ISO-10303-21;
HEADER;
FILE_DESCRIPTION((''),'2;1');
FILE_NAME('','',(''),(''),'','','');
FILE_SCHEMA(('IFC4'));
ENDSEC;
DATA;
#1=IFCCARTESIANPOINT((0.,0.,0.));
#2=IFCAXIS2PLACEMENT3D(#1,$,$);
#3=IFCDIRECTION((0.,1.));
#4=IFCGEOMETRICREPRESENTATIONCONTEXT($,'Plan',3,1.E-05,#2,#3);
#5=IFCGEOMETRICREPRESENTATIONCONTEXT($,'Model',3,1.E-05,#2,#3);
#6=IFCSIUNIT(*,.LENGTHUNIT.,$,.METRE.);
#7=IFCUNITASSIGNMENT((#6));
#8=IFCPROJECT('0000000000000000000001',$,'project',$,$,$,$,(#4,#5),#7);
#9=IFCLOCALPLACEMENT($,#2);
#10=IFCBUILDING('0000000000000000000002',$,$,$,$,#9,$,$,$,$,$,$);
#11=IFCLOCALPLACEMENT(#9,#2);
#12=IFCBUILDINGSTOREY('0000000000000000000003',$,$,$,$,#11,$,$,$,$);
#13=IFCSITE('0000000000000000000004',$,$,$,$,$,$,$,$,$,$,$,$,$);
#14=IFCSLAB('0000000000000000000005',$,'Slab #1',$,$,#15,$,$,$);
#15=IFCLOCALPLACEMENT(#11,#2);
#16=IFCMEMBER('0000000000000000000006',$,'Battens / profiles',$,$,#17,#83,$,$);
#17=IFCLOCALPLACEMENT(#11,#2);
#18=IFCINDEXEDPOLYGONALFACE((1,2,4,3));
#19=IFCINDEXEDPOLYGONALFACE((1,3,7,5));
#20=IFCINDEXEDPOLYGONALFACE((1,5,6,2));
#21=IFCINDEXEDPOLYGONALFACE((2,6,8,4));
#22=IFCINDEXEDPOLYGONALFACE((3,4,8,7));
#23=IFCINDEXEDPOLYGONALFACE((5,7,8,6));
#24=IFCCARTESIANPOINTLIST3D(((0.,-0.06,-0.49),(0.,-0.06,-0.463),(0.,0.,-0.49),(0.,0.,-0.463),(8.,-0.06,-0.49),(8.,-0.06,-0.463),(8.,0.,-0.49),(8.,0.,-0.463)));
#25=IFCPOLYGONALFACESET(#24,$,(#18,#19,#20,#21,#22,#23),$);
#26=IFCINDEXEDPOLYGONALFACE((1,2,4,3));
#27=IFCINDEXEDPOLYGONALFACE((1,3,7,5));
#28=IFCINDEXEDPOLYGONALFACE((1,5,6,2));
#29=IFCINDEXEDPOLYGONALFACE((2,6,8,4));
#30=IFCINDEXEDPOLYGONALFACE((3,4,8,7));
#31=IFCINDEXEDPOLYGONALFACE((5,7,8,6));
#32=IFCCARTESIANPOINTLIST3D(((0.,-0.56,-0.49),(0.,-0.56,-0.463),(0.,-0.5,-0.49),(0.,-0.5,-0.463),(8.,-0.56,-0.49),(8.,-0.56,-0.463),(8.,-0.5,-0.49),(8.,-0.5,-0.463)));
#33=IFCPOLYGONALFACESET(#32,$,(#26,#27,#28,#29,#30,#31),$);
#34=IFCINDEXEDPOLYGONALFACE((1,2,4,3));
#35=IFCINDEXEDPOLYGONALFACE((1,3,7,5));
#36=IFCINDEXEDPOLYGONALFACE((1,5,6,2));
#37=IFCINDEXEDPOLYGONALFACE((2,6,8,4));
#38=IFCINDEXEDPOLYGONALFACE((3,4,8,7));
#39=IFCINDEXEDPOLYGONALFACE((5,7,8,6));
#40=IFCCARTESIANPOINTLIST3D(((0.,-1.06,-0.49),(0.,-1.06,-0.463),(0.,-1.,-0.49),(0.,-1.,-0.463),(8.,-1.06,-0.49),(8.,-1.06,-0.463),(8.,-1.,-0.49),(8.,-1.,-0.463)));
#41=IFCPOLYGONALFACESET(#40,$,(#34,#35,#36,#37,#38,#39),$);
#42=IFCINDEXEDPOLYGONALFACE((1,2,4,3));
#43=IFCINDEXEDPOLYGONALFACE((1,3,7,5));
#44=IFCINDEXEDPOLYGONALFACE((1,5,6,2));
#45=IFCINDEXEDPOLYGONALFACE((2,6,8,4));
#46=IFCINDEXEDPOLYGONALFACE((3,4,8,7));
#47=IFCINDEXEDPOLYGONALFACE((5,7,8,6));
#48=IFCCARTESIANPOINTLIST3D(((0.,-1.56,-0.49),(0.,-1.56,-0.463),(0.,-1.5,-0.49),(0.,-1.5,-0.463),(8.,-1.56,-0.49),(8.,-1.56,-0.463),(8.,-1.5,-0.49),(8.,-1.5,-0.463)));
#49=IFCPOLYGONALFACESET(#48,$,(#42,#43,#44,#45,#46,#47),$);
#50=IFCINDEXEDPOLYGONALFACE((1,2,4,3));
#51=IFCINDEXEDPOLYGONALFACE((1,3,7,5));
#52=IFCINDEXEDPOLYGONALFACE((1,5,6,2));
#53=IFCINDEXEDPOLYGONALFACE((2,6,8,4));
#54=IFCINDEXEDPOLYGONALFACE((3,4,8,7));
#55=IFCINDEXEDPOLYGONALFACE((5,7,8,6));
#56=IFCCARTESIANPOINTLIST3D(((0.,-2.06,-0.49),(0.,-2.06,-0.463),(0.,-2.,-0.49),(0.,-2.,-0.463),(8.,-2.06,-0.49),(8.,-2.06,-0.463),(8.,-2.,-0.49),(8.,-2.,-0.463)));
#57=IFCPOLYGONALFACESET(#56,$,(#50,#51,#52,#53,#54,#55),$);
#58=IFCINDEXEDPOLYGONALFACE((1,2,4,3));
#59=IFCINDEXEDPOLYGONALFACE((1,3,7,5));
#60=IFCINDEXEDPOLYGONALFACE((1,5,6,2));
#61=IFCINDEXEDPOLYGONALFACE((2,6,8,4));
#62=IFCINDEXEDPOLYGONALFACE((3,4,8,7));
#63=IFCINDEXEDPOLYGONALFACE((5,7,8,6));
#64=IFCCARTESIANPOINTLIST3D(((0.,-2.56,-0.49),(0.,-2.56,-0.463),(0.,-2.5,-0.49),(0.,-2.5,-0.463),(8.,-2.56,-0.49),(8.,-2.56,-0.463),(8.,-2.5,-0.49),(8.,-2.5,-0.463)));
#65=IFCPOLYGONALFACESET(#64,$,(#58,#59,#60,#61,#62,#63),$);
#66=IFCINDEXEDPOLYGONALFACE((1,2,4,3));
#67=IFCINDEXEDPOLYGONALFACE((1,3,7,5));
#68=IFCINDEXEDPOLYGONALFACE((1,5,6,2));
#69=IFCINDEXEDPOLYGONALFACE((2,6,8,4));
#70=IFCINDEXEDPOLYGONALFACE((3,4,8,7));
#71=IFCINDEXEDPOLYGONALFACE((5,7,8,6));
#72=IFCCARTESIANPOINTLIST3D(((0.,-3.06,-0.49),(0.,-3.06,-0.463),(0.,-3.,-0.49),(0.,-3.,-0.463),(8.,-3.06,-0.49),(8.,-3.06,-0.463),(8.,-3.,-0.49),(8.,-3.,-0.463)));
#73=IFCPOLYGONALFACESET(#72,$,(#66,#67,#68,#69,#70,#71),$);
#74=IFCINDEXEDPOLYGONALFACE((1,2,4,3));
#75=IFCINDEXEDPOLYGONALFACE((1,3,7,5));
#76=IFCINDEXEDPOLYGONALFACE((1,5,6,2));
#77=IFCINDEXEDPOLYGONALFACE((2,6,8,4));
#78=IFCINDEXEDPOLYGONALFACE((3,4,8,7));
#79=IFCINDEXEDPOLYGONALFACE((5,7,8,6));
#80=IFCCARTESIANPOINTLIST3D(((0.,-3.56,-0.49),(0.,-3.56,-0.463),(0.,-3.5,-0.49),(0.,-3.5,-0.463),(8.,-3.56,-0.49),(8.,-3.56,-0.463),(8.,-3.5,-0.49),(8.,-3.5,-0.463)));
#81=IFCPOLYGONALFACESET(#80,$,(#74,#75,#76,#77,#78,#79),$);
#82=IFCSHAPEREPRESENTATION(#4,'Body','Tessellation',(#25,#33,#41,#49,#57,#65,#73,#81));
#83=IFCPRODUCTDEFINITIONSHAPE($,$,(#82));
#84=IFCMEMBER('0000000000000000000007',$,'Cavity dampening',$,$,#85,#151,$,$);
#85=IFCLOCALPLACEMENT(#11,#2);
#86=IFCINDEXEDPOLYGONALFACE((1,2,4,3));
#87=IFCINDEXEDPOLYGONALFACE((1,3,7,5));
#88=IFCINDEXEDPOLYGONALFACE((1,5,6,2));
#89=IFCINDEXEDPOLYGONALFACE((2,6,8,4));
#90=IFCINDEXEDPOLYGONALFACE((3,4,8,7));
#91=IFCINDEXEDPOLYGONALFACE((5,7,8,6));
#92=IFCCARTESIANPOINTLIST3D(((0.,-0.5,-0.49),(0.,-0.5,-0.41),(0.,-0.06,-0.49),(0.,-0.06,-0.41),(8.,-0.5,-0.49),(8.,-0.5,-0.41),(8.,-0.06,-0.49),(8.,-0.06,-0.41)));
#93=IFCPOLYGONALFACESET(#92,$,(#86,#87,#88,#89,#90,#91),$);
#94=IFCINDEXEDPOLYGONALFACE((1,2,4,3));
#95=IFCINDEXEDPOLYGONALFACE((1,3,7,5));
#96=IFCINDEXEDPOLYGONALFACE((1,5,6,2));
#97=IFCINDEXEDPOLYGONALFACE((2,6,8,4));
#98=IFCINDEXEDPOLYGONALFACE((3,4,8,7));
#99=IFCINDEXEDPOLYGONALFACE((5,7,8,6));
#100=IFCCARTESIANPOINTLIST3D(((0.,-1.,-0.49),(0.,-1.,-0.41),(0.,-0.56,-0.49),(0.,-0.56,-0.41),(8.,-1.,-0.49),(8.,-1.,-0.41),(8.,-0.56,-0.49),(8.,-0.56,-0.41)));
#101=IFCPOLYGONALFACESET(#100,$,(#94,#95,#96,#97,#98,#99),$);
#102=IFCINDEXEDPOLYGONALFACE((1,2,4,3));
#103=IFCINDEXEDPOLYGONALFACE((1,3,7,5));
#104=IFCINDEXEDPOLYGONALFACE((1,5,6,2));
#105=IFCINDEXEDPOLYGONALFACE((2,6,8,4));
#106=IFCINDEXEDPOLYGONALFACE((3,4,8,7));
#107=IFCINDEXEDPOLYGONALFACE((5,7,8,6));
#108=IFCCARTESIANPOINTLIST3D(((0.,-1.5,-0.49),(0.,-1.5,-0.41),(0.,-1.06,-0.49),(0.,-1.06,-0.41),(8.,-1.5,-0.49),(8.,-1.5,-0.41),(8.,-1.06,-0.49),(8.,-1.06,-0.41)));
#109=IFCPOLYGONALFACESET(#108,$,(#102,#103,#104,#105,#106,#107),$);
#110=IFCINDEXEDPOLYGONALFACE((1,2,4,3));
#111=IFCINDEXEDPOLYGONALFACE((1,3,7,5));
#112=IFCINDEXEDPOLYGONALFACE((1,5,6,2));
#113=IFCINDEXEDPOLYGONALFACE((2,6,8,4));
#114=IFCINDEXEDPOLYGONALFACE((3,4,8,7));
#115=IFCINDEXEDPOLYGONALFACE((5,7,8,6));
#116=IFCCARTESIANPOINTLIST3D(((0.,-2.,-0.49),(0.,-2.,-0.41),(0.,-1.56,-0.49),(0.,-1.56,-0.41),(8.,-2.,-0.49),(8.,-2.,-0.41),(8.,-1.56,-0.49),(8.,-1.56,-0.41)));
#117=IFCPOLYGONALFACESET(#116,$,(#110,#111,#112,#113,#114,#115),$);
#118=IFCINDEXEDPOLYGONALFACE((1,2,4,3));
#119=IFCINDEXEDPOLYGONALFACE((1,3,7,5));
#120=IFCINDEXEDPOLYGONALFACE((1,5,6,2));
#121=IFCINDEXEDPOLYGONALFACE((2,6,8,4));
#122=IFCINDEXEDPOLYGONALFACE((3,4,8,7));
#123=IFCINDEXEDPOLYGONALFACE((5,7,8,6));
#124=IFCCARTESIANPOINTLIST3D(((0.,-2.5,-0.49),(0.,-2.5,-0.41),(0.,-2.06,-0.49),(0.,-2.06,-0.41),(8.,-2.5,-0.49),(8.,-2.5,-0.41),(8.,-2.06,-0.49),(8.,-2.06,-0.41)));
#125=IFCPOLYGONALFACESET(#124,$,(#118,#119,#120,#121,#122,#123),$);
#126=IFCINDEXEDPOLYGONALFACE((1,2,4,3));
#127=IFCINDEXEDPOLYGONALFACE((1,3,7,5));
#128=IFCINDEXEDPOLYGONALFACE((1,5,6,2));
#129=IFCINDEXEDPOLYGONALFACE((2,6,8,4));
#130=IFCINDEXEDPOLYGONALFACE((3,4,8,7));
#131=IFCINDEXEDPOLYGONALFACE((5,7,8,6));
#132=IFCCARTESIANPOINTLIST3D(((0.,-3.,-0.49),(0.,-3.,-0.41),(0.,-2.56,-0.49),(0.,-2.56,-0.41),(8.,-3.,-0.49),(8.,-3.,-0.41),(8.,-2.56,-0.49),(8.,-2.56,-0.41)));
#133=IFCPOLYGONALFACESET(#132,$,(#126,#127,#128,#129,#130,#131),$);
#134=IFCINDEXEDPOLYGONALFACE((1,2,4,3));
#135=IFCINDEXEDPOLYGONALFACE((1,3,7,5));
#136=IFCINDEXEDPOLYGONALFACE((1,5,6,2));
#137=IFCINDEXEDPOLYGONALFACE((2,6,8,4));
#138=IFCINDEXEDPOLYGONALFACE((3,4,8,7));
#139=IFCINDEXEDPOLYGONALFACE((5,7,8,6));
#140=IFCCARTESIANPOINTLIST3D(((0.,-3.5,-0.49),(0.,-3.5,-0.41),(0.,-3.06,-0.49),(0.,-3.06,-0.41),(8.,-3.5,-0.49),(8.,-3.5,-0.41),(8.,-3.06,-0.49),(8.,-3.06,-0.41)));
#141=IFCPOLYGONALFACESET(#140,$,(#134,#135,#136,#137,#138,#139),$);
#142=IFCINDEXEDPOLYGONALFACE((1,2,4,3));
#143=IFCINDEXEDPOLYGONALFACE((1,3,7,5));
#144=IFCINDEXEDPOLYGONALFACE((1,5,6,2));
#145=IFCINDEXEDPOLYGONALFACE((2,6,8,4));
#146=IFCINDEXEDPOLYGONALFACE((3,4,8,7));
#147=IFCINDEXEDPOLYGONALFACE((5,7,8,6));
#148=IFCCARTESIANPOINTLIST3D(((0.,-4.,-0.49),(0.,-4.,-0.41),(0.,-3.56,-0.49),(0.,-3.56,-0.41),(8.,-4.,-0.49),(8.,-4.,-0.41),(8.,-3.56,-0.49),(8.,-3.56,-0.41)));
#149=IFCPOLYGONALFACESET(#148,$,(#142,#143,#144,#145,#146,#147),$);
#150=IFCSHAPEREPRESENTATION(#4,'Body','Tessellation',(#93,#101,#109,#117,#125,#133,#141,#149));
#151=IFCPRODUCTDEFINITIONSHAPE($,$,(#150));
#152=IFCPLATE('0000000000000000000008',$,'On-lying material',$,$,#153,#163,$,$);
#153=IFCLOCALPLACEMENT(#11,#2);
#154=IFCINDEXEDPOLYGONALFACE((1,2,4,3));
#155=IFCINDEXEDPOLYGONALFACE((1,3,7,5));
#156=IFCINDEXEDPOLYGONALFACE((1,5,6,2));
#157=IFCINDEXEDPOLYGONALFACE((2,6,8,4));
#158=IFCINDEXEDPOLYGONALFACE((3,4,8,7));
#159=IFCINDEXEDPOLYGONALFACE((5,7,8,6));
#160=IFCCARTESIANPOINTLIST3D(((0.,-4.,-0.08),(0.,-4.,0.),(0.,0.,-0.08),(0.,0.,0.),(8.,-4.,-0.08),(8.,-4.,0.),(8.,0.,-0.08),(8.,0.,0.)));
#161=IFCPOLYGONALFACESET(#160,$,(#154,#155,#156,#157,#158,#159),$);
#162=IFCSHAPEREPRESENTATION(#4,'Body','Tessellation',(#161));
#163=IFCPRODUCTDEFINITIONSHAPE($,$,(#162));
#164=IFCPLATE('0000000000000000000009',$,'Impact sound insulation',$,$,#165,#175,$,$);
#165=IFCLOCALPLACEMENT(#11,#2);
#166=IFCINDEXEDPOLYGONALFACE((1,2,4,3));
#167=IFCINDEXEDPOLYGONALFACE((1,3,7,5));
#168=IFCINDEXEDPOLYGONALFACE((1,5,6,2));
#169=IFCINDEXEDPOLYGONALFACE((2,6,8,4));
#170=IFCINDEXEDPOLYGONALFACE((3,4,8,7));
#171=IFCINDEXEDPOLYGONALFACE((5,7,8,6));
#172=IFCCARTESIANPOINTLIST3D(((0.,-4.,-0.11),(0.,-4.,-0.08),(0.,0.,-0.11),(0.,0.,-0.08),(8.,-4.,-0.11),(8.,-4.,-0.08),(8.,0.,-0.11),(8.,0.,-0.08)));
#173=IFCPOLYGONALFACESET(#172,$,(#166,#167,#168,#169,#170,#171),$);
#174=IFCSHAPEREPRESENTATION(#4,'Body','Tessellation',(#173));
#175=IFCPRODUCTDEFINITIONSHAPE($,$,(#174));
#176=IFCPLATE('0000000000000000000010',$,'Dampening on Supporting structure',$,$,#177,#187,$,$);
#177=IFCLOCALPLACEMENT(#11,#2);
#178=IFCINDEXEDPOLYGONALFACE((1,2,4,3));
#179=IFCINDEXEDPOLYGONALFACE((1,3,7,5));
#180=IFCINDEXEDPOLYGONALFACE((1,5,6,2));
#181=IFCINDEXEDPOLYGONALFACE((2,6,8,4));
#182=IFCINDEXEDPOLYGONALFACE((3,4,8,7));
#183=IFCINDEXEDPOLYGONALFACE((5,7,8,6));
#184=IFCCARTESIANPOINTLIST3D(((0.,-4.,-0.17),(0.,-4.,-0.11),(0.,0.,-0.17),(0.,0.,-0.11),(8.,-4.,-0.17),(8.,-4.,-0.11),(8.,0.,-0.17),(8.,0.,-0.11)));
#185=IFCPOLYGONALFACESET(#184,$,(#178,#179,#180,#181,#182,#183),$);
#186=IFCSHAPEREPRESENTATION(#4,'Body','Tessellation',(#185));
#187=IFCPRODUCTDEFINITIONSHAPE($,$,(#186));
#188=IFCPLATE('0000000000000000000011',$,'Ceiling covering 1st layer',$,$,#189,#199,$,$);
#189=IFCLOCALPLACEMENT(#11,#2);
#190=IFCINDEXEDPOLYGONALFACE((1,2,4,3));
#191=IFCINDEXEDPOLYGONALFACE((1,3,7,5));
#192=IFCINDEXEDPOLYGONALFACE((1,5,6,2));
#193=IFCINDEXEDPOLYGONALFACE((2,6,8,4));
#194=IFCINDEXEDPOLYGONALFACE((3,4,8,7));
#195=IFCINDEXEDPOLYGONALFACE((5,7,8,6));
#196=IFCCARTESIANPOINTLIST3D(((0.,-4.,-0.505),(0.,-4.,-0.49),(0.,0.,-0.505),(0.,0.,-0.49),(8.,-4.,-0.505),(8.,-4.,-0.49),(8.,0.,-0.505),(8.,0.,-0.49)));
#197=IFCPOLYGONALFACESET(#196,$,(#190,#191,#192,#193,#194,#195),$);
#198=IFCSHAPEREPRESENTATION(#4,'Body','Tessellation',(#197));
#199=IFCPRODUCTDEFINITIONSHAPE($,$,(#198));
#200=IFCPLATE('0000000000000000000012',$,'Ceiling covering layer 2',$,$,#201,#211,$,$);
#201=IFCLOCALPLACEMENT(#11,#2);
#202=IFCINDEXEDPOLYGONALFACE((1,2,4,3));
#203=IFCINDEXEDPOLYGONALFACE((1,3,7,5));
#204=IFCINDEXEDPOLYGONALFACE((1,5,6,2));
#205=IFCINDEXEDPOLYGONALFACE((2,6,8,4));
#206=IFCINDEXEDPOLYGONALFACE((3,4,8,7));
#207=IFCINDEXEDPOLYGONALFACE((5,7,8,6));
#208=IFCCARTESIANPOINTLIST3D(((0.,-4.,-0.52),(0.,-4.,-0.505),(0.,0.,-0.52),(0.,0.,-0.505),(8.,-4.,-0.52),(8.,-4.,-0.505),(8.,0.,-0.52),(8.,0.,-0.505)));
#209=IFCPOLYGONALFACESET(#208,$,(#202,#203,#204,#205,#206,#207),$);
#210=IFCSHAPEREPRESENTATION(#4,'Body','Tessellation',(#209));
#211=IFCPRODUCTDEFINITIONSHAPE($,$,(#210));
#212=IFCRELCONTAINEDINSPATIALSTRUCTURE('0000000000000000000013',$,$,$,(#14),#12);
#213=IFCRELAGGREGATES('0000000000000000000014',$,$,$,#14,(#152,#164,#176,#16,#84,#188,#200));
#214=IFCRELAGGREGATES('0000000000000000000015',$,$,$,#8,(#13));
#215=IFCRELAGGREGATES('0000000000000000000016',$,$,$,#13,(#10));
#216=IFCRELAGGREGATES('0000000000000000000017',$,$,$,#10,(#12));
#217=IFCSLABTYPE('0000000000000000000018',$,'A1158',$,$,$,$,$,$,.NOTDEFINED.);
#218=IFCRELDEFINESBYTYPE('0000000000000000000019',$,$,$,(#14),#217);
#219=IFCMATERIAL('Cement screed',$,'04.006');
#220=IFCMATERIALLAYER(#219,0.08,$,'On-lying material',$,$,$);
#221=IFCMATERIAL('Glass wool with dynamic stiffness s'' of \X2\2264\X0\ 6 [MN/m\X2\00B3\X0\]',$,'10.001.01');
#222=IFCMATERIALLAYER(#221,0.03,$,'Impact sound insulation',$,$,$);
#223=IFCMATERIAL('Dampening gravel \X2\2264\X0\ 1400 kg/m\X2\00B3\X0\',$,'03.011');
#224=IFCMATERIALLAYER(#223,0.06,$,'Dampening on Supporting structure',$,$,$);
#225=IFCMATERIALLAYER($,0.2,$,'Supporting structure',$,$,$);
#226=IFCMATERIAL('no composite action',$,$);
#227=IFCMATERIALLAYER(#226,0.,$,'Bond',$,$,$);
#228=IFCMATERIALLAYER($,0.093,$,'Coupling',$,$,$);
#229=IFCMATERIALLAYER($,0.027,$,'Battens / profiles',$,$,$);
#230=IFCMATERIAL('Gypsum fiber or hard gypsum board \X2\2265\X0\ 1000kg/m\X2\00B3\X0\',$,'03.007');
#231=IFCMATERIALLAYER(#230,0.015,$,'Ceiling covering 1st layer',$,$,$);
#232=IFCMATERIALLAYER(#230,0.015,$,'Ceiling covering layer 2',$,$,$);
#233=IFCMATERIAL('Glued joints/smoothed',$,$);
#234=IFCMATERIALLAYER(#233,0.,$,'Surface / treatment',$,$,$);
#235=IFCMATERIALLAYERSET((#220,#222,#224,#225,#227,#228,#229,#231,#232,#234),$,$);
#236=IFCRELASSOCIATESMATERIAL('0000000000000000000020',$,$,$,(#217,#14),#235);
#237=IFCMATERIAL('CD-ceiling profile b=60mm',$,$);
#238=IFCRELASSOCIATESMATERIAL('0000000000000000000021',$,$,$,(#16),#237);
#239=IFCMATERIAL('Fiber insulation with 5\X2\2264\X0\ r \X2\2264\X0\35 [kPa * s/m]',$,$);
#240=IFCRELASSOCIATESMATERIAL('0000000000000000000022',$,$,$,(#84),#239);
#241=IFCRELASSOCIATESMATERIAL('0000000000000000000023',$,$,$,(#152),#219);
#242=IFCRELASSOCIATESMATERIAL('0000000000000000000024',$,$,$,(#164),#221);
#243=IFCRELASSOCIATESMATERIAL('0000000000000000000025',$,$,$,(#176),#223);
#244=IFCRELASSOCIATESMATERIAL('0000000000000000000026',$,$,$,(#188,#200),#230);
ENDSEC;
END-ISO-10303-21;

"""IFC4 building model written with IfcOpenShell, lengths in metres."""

from ifc_helpers import new_model, si_unit, direction, frame, frame_2d, origin, origin_with_axes, place, context, project, spatial, rectangle, extrude, material, layer, layer_set, type_object, element, aggregate, save


model = new_model("IFC4")

# Units and contexts
plan_context = context("Plan", 3, precision=1e-05, world=origin(), true_north=direction((0.0, 1.0)))
model_context = context("Model", 3, precision=1e-05, world=origin(), true_north=direction((0.0, 1.0)))
ifc_project = project(units=[si_unit("LENGTHUNIT", "METRE")], contexts=[plan_context, model_context])

# Site, building, storey
site = spatial("IfcSite", under=ifc_project)
building_placement = place(None, origin())
building = spatial("IfcBuilding", under=site, at=building_placement)
storey_placement = place(building_placement, origin())
storey = spatial("IfcBuildingStorey", under=building, at=storey_placement)

# Slab, members, plates
ifc_material_1 = material(Name="Cement screed", Category="04.006")
ifc_layer_1 = layer(ifc_material_1, 0.08, Name="On-lying material")
ifc_material_2 = material(Name="Glass wool with dynamic stiffness s' of ≤ 6 [MN/m³]", Category="10.001.01")
ifc_layer_2 = layer(ifc_material_2, 0.03, Name="Impact sound insulation")
ifc_material_3 = material(Name="Dampening gravel ≤ 1400 kg/m³", Category="03.011")
ifc_layer_3 = layer(ifc_material_3, 0.06, Name="Dampening on Supporting structure")
ifc_layer_4 = layer(None, 0.2, Name="Supporting structure")
ifc_material_4 = material(Name="no composite action")
ifc_layer_5 = layer(ifc_material_4, 0.0, Name="Bond")
ifc_layer_6 = layer(None, 0.093, Name="Coupling")
ifc_layer_7 = layer(None, 0.027, Name="Battens / profiles")
ifc_material_5 = material(Name="Gypsum fiber or hard gypsum board ≥ 1000kg/m³", Category="03.007")
ifc_layer_8 = layer(ifc_material_5, 0.015, Name="Ceiling covering 1st layer")
ifc_layer_9 = layer(ifc_material_5, 0.015, Name="Ceiling covering layer 2")
ifc_material_6 = material(Name="Glued joints/smoothed")
ifc_layer_10 = layer(ifc_material_6, 0.0, Name="Surface / treatment")
ifc_layer_set = layer_set([ifc_layer_1, ifc_layer_2, ifc_layer_3, ifc_layer_4, ifc_layer_5, ifc_layer_6, ifc_layer_7, ifc_layer_8, ifc_layer_9, ifc_layer_10])
slab_type = type_object("IfcSlabType", Name="A1158", PredefinedType="NOTDEFINED", material=ifc_layer_set)
slab_placement = place(None, frame((0.0, 0.0, 0.0), z_axis=(0.0, 0.0, -1.0), x_axis=(1.0, 0.0, 0.0)))
slab = element("IfcSlab", 1, at=slab_placement, inside=storey, type_object=slab_type, material=ifc_layer_set, Name="Slab #1")
ifc_material_7 = material(Name="CD-ceiling profile b=60mm")
member_1_placement = place(slab_placement, origin())
member_1 = element("IfcMember", 2, at=member_1_placement, material=ifc_material_7, Name="Battens / profiles", context=plan_context, shape_type="SweptSolid", body=[
    extrude(rectangle(XDim=0.06, YDim=0.027, at=frame_2d((0.03, 0.0135), x_axis=(1.0, 0.0))), frame((0.0, 0.0, 0.463), z_axis=(1.0, 0.0, 0.0), x_axis=(0.0, 1.0, 0.0)), (0.0, 0.0, 1.0), 8.0),
    extrude(rectangle(XDim=0.06, YDim=0.027, at=frame_2d((0.03, 0.0135), x_axis=(1.0, 0.0))), frame((0.0, 0.5, 0.463), z_axis=(1.0, 0.0, 0.0), x_axis=(0.0, 1.0, 0.0)), (0.0, 0.0, 1.0), 8.0),
    extrude(rectangle(XDim=0.06, YDim=0.027, at=frame_2d((0.03, 0.0135), x_axis=(1.0, 0.0))), frame((0.0, 1.0, 0.463), z_axis=(1.0, 0.0, 0.0), x_axis=(0.0, 1.0, 0.0)), (0.0, 0.0, 1.0), 8.0),
    extrude(rectangle(XDim=0.06, YDim=0.027, at=frame_2d((0.03, 0.0135), x_axis=(1.0, 0.0))), frame((0.0, 1.5, 0.463), z_axis=(1.0, 0.0, 0.0), x_axis=(0.0, 1.0, 0.0)), (0.0, 0.0, 1.0), 8.0),
    extrude(rectangle(XDim=0.06, YDim=0.027, at=frame_2d((0.03, 0.0135), x_axis=(1.0, 0.0))), frame((0.0, 2.0, 0.463), z_axis=(1.0, 0.0, 0.0), x_axis=(0.0, 1.0, 0.0)), (0.0, 0.0, 1.0), 8.0),
    extrude(rectangle(XDim=0.06, YDim=0.027, at=frame_2d((0.03, 0.0135), x_axis=(1.0, 0.0))), frame((0.0, 2.5, 0.463), z_axis=(1.0, 0.0, 0.0), x_axis=(0.0, 1.0, 0.0)), (0.0, 0.0, 1.0), 8.0),
    extrude(rectangle(XDim=0.06, YDim=0.027, at=frame_2d((0.03, 0.0135), x_axis=(1.0, 0.0))), frame((0.0, 3.0, 0.463), z_axis=(1.0, 0.0, 0.0), x_axis=(0.0, 1.0, 0.0)), (0.0, 0.0, 1.0), 8.0),
    extrude(rectangle(XDim=0.06, YDim=0.027, at=frame_2d((0.03, 0.0135), x_axis=(1.0, 0.0))), frame((0.0, 3.5, 0.463), z_axis=(1.0, 0.0, 0.0), x_axis=(0.0, 1.0, 0.0)), (0.0, 0.0, 1.0), 8.0),
])
ifc_material_8 = material(Name="Fiber insulation with 5≤ r ≤35 [kPa * s/m]")
member_2_placement = place(slab_placement, origin())
member_2 = element("IfcMember", 3, at=member_2_placement, material=ifc_material_8, Name="Cavity dampening", context=plan_context, shape_type="SweptSolid", body=[
    extrude(rectangle(XDim=0.44, YDim=0.08, at=frame_2d((0.22, 0.04), x_axis=(1.0, 0.0))), frame((0.0, 0.06, 0.41), z_axis=(1.0, 0.0, 0.0), x_axis=(0.0, 1.0, 0.0)), (0.0, 0.0, 1.0), 8.0),
    extrude(rectangle(XDim=0.44, YDim=0.08, at=frame_2d((0.22, 0.04), x_axis=(1.0, 0.0))), frame((0.0, 0.56, 0.41), z_axis=(1.0, 0.0, 0.0), x_axis=(0.0, 1.0, 0.0)), (0.0, 0.0, 1.0), 8.0),
    extrude(rectangle(XDim=0.44, YDim=0.08, at=frame_2d((0.22, 0.04), x_axis=(1.0, 0.0))), frame((0.0, 1.06, 0.41), z_axis=(1.0, 0.0, 0.0), x_axis=(0.0, 1.0, 0.0)), (0.0, 0.0, 1.0), 8.0),
    extrude(rectangle(XDim=0.44, YDim=0.08, at=frame_2d((0.22, 0.04), x_axis=(1.0, 0.0))), frame((0.0, 1.56, 0.41), z_axis=(1.0, 0.0, 0.0), x_axis=(0.0, 1.0, 0.0)), (0.0, 0.0, 1.0), 8.0),
    extrude(rectangle(XDim=0.44, YDim=0.08, at=frame_2d((0.22, 0.04), x_axis=(1.0, 0.0))), frame((0.0, 2.06, 0.41), z_axis=(1.0, 0.0, 0.0), x_axis=(0.0, 1.0, 0.0)), (0.0, 0.0, 1.0), 8.0),
    extrude(rectangle(XDim=0.44, YDim=0.08, at=frame_2d((0.22, 0.04), x_axis=(1.0, 0.0))), frame((0.0, 2.56, 0.41), z_axis=(1.0, 0.0, 0.0), x_axis=(0.0, 1.0, 0.0)), (0.0, 0.0, 1.0), 8.0),
    extrude(rectangle(XDim=0.44, YDim=0.08, at=frame_2d((0.22, 0.04), x_axis=(1.0, 0.0))), frame((0.0, 3.06, 0.41), z_axis=(1.0, 0.0, 0.0), x_axis=(0.0, 1.0, 0.0)), (0.0, 0.0, 1.0), 8.0),
    extrude(rectangle(XDim=0.44, YDim=0.08, at=frame_2d((0.22, 0.04), x_axis=(1.0, 0.0))), frame((0.0, 3.56, 0.41), z_axis=(1.0, 0.0, 0.0), x_axis=(0.0, 1.0, 0.0)), (0.0, 0.0, 1.0), 8.0),
])
plate_1_placement = place(slab_placement, origin())
plate_1 = element("IfcPlate", 4, at=plate_1_placement, material=ifc_material_1, Name="On-lying material", context=plan_context, shape_type="SweptSolid", body=[
    extrude(rectangle(XDim=8.0, YDim=4.0, at=frame_2d((4.0, 2.0), x_axis=(1.0, 0.0))), origin_with_axes(), (0.0, 0.0, 1.0), 0.08),
])
plate_2_placement = place(slab_placement, origin())
plate_2 = element("IfcPlate", 5, at=plate_2_placement, material=ifc_material_2, Name="Impact sound insulation", context=plan_context, shape_type="SweptSolid", body=[
    extrude(rectangle(XDim=8.0, YDim=4.0, at=frame_2d((4.0, 2.0), x_axis=(1.0, 0.0))), frame((0.0, 0.0, 0.08), z_axis=(0.0, 0.0, 1.0), x_axis=(1.0, 0.0, 0.0)), (0.0, 0.0, 1.0), 0.03),
])
plate_3_placement = place(slab_placement, origin())
plate_3 = element("IfcPlate", 6, at=plate_3_placement, material=ifc_material_3, Name="Dampening on Supporting structure", context=plan_context, shape_type="SweptSolid", body=[
    extrude(rectangle(XDim=8.0, YDim=4.0, at=frame_2d((4.0, 2.0), x_axis=(1.0, 0.0))), frame((0.0, 0.0, 0.11), z_axis=(0.0, 0.0, 1.0), x_axis=(1.0, 0.0, 0.0)), (0.0, 0.0, 1.0), 0.06),
])
plate_4_placement = place(slab_placement, origin())
plate_4 = element("IfcPlate", 7, at=plate_4_placement, material=ifc_material_5, Name="Ceiling covering 1st layer", context=plan_context, shape_type="SweptSolid", body=[
    extrude(rectangle(XDim=8.0, YDim=4.0, at=frame_2d((4.0, 2.0), x_axis=(1.0, 0.0))), frame((0.0, 0.0, 0.49), z_axis=(0.0, 0.0, 1.0), x_axis=(1.0, 0.0, 0.0)), (0.0, 0.0, 1.0), 0.015),
])
plate_5_placement = place(slab_placement, origin())
plate_5 = element("IfcPlate", 8, at=plate_5_placement, material=ifc_material_5, Name="Ceiling covering layer 2", context=plan_context, shape_type="SweptSolid", body=[
    extrude(rectangle(XDim=8.0, YDim=4.0, at=frame_2d((4.0, 2.0), x_axis=(1.0, 0.0))), frame((0.0, 0.0, 0.505), z_axis=(0.0, 0.0, 1.0), x_axis=(1.0, 0.0, 0.0)), (0.0, 0.0, 1.0), 0.015),
])
aggregate(slab, [plate_1, plate_2, plate_3, member_1, member_2, plate_4, plate_5])

save(model, "model.ifc")
